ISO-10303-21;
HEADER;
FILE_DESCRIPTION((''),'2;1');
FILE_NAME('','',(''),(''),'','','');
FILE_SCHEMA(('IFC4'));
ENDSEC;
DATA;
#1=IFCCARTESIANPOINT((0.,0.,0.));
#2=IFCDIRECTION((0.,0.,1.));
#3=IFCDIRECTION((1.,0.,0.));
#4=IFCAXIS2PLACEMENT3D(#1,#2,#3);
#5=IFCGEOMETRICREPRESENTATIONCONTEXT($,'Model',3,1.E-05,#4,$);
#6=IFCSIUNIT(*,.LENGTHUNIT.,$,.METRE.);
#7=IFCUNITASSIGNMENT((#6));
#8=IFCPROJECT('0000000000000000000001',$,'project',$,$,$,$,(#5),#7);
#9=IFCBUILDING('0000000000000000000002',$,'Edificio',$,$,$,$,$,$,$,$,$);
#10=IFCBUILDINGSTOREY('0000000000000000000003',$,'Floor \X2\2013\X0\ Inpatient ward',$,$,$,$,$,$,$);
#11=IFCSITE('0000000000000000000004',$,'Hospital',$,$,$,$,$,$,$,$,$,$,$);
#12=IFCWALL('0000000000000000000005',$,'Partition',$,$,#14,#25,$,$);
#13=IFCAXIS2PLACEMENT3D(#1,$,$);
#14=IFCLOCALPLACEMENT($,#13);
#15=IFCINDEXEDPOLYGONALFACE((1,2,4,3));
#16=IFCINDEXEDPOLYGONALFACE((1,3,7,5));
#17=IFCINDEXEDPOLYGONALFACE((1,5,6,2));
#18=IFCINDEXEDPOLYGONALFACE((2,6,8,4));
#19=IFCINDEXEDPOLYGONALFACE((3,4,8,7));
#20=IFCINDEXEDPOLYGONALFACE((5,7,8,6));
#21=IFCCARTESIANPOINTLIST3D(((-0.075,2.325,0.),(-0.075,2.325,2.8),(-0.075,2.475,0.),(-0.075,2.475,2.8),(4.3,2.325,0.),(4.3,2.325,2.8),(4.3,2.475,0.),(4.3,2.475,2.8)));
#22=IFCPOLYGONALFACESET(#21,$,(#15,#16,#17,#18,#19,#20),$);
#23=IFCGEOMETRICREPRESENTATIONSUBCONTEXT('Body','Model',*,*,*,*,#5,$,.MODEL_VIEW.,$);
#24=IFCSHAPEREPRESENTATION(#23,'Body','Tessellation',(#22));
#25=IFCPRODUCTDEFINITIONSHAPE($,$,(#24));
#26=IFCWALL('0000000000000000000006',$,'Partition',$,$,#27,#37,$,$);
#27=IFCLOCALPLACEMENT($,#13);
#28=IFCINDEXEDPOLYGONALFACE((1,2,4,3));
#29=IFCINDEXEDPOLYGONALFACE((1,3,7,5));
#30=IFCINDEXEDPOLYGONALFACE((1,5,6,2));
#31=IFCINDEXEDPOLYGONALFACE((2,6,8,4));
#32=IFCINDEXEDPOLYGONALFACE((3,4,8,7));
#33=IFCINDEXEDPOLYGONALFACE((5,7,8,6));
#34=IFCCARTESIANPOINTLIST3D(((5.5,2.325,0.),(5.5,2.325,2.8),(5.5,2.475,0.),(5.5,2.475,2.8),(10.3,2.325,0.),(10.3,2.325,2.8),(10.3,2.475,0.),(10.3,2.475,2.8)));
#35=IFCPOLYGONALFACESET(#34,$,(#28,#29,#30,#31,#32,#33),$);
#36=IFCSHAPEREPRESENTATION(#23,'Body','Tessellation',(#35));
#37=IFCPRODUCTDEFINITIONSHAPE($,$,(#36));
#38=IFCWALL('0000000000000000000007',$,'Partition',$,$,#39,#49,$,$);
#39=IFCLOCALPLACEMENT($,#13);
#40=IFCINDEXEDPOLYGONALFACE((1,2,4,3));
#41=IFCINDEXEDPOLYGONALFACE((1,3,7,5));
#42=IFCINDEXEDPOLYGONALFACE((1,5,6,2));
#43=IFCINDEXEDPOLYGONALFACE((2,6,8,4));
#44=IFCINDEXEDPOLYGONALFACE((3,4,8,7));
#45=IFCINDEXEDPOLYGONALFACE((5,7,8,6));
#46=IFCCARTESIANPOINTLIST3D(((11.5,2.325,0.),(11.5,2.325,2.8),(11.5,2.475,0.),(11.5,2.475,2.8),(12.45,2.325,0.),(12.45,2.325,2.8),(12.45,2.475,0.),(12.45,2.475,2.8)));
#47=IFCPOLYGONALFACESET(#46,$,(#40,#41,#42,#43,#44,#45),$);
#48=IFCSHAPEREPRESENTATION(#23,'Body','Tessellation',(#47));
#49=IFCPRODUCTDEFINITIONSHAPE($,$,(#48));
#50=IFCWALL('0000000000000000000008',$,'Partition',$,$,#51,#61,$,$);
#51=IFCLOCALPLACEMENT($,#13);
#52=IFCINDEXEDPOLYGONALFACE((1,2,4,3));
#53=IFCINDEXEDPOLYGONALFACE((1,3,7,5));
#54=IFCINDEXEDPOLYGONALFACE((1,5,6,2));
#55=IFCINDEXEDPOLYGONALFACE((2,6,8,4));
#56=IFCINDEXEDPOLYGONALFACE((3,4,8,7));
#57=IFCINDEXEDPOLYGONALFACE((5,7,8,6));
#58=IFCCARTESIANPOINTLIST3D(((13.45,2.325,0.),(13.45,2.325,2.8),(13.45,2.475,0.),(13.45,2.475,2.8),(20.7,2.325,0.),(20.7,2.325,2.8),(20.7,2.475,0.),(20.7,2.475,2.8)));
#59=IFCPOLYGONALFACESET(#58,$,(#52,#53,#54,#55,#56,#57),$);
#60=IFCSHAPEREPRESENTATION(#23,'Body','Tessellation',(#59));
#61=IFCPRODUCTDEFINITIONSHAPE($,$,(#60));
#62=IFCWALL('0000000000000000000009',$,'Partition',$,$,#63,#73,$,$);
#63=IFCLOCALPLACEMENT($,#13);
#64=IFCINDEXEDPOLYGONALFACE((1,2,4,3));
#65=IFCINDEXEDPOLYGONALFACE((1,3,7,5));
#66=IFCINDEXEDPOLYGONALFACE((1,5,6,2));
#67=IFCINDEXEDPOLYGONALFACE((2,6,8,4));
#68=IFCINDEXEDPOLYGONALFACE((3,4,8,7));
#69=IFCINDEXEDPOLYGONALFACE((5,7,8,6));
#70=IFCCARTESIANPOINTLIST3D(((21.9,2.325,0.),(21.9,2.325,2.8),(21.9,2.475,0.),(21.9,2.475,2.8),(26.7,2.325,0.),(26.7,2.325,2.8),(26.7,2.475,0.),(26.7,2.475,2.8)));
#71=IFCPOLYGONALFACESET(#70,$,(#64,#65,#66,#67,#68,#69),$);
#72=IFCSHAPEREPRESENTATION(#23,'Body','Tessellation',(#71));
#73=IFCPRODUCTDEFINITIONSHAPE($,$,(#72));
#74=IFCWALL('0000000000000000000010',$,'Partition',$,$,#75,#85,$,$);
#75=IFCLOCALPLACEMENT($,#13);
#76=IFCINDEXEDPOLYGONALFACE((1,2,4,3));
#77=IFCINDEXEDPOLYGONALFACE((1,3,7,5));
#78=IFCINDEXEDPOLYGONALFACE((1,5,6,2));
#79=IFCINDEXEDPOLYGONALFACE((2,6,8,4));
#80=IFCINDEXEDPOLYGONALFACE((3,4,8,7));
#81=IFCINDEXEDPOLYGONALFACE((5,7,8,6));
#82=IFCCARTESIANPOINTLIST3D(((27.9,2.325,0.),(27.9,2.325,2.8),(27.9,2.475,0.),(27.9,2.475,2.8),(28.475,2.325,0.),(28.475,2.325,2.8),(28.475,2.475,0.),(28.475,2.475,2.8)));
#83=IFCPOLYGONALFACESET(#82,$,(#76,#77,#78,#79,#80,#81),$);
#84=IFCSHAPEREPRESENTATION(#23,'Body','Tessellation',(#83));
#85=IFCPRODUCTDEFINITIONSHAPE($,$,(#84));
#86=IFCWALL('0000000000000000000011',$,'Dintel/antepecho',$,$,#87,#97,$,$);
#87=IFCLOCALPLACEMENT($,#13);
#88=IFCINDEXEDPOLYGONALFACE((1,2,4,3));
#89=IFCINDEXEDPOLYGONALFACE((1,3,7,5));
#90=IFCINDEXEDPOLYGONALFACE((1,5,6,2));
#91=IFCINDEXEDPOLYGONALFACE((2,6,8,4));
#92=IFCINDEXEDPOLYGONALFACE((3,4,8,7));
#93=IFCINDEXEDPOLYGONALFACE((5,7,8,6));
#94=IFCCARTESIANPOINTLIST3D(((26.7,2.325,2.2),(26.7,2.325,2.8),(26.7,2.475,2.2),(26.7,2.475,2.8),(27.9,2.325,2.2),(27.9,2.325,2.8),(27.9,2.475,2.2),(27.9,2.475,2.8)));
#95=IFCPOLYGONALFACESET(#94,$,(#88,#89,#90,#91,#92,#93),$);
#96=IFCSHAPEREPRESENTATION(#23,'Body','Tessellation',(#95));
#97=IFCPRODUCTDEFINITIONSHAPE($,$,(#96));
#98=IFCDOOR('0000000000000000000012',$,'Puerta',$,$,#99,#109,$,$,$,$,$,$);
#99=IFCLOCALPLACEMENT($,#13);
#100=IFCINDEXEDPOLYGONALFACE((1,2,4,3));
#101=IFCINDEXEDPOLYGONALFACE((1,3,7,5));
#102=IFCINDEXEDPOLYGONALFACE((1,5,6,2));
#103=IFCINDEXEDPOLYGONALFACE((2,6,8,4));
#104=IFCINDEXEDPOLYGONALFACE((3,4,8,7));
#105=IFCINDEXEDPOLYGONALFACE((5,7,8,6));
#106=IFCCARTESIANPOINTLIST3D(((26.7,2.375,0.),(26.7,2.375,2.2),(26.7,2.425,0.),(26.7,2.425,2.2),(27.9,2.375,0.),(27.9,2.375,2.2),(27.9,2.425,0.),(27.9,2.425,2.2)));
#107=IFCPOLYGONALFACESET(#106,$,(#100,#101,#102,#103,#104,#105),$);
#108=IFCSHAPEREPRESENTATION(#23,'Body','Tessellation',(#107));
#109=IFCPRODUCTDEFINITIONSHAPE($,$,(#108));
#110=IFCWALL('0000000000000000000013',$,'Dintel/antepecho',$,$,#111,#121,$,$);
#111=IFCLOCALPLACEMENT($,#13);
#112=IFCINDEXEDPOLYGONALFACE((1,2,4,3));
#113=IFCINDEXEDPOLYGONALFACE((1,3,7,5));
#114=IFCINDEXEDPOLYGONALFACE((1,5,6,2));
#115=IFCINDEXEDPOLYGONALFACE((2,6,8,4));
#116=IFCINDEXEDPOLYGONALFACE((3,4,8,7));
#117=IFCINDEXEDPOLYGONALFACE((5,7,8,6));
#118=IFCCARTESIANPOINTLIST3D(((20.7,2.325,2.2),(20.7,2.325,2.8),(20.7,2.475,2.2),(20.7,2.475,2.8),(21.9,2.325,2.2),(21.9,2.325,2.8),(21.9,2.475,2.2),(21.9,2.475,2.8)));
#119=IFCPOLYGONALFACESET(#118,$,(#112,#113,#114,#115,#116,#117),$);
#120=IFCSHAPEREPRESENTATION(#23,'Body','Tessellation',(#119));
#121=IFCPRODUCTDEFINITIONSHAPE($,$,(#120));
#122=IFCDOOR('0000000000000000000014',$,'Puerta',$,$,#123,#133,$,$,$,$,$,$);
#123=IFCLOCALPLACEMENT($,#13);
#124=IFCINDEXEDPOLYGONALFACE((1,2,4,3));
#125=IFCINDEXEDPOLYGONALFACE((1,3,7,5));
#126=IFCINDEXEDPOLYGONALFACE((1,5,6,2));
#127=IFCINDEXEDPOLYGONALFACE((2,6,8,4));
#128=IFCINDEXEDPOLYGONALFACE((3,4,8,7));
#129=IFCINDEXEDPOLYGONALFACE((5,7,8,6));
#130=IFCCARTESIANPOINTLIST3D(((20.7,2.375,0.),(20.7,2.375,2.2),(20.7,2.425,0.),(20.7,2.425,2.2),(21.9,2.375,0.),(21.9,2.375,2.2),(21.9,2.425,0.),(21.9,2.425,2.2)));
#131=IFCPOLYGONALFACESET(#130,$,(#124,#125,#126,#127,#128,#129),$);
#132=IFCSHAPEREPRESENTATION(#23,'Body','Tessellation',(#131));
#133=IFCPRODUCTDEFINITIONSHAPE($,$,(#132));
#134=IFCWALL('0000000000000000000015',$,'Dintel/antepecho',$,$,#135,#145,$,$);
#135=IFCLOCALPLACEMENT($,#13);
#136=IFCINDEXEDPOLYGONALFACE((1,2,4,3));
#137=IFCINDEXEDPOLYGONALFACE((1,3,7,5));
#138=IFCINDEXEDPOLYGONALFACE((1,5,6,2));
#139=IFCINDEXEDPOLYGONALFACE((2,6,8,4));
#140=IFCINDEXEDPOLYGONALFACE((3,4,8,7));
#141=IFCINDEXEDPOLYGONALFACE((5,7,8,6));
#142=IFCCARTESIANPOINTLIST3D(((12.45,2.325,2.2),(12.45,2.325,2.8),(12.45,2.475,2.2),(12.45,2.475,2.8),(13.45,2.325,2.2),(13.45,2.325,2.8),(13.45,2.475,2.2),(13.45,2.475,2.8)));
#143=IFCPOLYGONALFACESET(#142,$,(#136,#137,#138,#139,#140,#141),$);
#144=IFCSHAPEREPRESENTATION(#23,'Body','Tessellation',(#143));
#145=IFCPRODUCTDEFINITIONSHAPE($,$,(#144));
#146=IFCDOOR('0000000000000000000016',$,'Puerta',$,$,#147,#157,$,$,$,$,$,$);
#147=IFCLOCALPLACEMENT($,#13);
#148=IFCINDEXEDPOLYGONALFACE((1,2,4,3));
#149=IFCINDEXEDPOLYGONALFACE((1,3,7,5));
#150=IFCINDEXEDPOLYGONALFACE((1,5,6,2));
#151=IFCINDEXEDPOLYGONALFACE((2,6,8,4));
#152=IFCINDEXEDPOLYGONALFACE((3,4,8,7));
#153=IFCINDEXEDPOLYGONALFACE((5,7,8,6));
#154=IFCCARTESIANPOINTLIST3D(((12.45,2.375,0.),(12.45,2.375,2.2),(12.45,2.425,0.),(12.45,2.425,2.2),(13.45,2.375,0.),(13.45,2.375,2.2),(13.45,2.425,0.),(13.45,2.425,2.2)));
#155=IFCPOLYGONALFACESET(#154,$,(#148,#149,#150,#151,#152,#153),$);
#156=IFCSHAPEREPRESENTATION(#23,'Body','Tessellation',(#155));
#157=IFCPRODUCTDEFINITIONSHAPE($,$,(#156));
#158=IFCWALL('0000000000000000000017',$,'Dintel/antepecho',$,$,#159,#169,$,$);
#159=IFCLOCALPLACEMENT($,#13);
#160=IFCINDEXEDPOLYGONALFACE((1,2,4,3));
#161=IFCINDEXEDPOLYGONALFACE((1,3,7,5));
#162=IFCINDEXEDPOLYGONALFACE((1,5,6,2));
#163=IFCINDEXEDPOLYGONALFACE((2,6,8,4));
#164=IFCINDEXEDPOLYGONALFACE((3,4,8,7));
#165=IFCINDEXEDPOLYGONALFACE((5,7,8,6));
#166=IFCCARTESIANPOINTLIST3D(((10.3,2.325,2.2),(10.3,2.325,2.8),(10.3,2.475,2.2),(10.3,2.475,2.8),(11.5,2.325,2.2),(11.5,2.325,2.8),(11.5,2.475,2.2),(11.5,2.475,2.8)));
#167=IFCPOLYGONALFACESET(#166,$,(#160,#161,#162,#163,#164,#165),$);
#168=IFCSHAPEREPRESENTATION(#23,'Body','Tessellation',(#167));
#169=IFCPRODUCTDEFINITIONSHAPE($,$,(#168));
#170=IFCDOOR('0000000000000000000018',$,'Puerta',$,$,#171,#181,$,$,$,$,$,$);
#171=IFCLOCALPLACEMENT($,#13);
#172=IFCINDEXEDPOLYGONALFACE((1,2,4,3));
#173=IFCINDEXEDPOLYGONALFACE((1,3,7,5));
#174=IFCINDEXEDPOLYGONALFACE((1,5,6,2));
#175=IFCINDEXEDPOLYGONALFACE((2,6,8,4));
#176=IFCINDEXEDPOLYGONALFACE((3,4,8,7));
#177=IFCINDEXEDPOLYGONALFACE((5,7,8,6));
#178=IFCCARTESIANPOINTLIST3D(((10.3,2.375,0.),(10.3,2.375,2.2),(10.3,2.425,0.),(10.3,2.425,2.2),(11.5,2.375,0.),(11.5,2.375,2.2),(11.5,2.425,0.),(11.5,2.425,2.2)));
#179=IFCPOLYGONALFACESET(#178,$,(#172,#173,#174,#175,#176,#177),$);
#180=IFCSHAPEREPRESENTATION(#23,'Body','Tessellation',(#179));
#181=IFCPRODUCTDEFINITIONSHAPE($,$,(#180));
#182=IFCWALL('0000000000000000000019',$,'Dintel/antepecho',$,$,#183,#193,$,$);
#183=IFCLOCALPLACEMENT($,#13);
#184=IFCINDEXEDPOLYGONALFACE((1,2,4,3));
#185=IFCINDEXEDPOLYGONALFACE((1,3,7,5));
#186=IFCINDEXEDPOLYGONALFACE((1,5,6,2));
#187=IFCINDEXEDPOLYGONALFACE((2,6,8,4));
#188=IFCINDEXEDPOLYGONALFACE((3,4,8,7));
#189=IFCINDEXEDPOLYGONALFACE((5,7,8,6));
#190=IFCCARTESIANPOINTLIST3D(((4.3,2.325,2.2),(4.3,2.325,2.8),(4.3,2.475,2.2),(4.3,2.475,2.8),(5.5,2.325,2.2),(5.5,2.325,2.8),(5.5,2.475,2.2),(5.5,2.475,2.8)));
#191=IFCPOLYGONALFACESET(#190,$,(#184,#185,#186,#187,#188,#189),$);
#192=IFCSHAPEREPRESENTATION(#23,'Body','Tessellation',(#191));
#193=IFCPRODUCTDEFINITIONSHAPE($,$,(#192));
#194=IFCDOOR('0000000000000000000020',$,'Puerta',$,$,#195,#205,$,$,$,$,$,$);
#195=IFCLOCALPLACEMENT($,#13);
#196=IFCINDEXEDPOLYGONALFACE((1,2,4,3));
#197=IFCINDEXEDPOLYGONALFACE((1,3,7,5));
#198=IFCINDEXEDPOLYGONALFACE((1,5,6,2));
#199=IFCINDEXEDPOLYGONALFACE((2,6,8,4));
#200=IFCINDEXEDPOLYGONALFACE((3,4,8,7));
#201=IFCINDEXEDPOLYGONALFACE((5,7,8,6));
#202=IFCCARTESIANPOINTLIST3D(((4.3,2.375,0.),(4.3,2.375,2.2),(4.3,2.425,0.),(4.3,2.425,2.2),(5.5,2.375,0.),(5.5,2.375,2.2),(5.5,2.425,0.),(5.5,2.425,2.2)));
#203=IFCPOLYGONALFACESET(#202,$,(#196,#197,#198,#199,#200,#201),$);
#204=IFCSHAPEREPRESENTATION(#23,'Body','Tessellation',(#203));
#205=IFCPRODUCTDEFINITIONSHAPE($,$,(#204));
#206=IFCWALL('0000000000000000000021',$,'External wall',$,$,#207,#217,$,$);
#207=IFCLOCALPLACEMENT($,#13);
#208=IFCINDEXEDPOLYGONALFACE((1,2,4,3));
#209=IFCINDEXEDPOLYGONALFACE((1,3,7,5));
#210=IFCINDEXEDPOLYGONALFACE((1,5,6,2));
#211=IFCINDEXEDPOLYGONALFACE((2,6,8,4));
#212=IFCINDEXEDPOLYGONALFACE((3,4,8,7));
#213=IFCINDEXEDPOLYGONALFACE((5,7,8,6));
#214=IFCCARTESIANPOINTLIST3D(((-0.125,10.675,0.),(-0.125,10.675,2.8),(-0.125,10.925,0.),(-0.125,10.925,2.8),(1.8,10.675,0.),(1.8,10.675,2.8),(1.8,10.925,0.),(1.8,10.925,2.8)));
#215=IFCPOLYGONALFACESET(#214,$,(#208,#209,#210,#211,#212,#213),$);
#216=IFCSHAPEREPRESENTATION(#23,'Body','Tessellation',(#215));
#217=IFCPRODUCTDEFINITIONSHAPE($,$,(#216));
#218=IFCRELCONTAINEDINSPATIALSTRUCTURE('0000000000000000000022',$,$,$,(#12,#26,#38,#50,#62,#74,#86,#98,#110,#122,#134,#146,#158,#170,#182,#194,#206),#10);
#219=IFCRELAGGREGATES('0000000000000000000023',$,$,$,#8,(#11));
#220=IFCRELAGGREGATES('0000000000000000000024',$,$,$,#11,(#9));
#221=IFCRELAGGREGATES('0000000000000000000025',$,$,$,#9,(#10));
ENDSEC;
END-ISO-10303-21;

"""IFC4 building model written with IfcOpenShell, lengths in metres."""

from ifc_helpers import new_model, si_unit, frame, origin_with_axes, context, subcontext, project, spatial, line, indexed_curve, outline, extrude, element, save


model = new_model("IFC4")

# Units and contexts
model_context = context("Model", 3, precision=1e-05, world=origin_with_axes())
body_context = subcontext(model_context, "Body", "Model", "MODEL_VIEW")
ifc_project = project(units=[si_unit("LENGTHUNIT", "METRE")], contexts=[model_context])

# Site, building, storey
site = spatial("IfcSite", under=ifc_project, Name="Hospital")
building = spatial("IfcBuilding", under=site, Name="Edificio")
storey = spatial("IfcBuildingStorey", under=building, Name="Floor – Inpatient ward")

# Walls
element("IfcWall", 1, inside=storey, Name="Partition", context=body_context, shape_type="SweptSolid", body=[
    extrude(outline(indexed_curve([(0.0, 0.0), (4.375, 0.0), (4.375, 0.15), (0.0, 0.15)], segments=[line(1, 2, 3, 4, 1)])), frame((-0.075, 2.325, 0.0), z_axis=(0.0, 0.0, 1.0), x_axis=(1.0, 0.0, 0.0)), (0.0, 0.0, 1.0), 2.8),
])
element("IfcWall", 2, inside=storey, Name="Partition", context=body_context, shape_type="SweptSolid", body=[
    extrude(outline(indexed_curve([(0.0, 0.0), (4.8, 0.0), (4.8, 0.15), (0.0, 0.15)], segments=[line(1, 2, 3, 4, 1)])), frame((5.5, 2.325, 0.0), z_axis=(0.0, 0.0, 1.0), x_axis=(1.0, 0.0, 0.0)), (0.0, 0.0, 1.0), 2.8),
])
element("IfcWall", 3, inside=storey, Name="Partition", context=body_context, shape_type="SweptSolid", body=[
    extrude(outline(indexed_curve([(0.0, 0.0), (0.95, 0.0), (0.95, 0.15), (0.0, 0.15)], segments=[line(1, 2, 3, 4, 1)])), frame((11.5, 2.325, 0.0), z_axis=(0.0, 0.0, 1.0), x_axis=(1.0, 0.0, 0.0)), (0.0, 0.0, 1.0), 2.8),
])
element("IfcWall", 4, inside=storey, Name="Partition", context=body_context, shape_type="SweptSolid", body=[
    extrude(outline(indexed_curve([(0.0, 0.0), (7.25, 0.0), (7.25, 0.15), (0.0, 0.15)], segments=[line(1, 2, 3, 4, 1)])), frame((13.45, 2.325, 0.0), z_axis=(0.0, 0.0, 1.0), x_axis=(1.0, 0.0, 0.0)), (0.0, 0.0, 1.0), 2.8),
])
element("IfcWall", 5, inside=storey, Name="Partition", context=body_context, shape_type="SweptSolid", body=[
    extrude(outline(indexed_curve([(0.0, 0.0), (4.8, 0.0), (4.8, 0.15), (0.0, 0.15)], segments=[line(1, 2, 3, 4, 1)])), frame((21.9, 2.325, 0.0), z_axis=(0.0, 0.0, 1.0), x_axis=(1.0, 0.0, 0.0)), (0.0, 0.0, 1.0), 2.8),
])
element("IfcWall", 6, inside=storey, Name="Partition", context=body_context, shape_type="SweptSolid", body=[
    extrude(outline(indexed_curve([(0.0, 0.0), (0.575, 0.0), (0.575, 0.15), (0.0, 0.15)], segments=[line(1, 2, 3, 4, 1)])), frame((27.9, 2.325, 0.0), z_axis=(0.0, 0.0, 1.0), x_axis=(1.0, 0.0, 0.0)), (0.0, 0.0, 1.0), 2.8),
])
element("IfcWall", 7, inside=storey, Name="Dintel/antepecho", context=body_context, shape_type="SweptSolid", body=[
    extrude(outline(indexed_curve([(0.0, 0.0), (1.2, 0.0), (1.2, 0.15), (0.0, 0.15)], segments=[line(1, 2, 3, 4, 1)])), frame((26.7, 2.325, 2.2), z_axis=(0.0, 0.0, 1.0), x_axis=(1.0, 0.0, 0.0)), (0.0, 0.0, 1.0), 0.6),
])

# Door
element("IfcDoor", 8, inside=storey, Name="Puerta", context=body_context, shape_type="SweptSolid", body=[
    extrude(outline(indexed_curve([(0.0, 0.0), (1.2, 0.0), (1.2, 0.05), (0.0, 0.05)], segments=[line(1, 2, 3, 4, 1)])), frame((26.7, 2.375, 0.0), z_axis=(0.0, 0.0, 1.0), x_axis=(1.0, 0.0, 0.0)), (0.0, 0.0, 1.0), 2.2),
])

# Wall
element("IfcWall", 9, inside=storey, Name="Dintel/antepecho", context=body_context, shape_type="SweptSolid", body=[
    extrude(outline(indexed_curve([(0.0, 0.0), (1.2, 0.0), (1.2, 0.15), (0.0, 0.15)], segments=[line(1, 2, 3, 4, 1)])), frame((20.7, 2.325, 2.2), z_axis=(0.0, 0.0, 1.0), x_axis=(1.0, 0.0, 0.0)), (0.0, 0.0, 1.0), 0.6),
])

# Door
element("IfcDoor", 10, inside=storey, Name="Puerta", context=body_context, shape_type="SweptSolid", body=[
    extrude(outline(indexed_curve([(0.0, 0.0), (1.2, 0.0), (1.2, 0.05), (0.0, 0.05)], segments=[line(1, 2, 3, 4, 1)])), frame((20.7, 2.375, 0.0), z_axis=(0.0, 0.0, 1.0), x_axis=(1.0, 0.0, 0.0)), (0.0, 0.0, 1.0), 2.2),
])

# Wall
element("IfcWall", 11, inside=storey, Name="Dintel/antepecho", context=body_context, shape_type="SweptSolid", body=[
    extrude(outline(indexed_curve([(0.0, 0.0), (1.0, 0.0), (1.0, 0.15), (0.0, 0.15)], segments=[line(1, 2, 3, 4, 1)])), frame((12.45, 2.325, 2.2), z_axis=(0.0, 0.0, 1.0), x_axis=(1.0, 0.0, 0.0)), (0.0, 0.0, 1.0), 0.6),
])

# Door
element("IfcDoor", 12, inside=storey, Name="Puerta", context=body_context, shape_type="SweptSolid", body=[
    extrude(outline(indexed_curve([(0.0, 0.0), (1.0, 0.0), (1.0, 0.05), (0.0, 0.05)], segments=[line(1, 2, 3, 4, 1)])), frame((12.45, 2.375, 0.0), z_axis=(0.0, 0.0, 1.0), x_axis=(1.0, 0.0, 0.0)), (0.0, 0.0, 1.0), 2.2),
])

# Wall
element("IfcWall", 13, inside=storey, Name="Dintel/antepecho", context=body_context, shape_type="SweptSolid", body=[
    extrude(outline(indexed_curve([(0.0, 0.0), (1.2, 0.0), (1.2, 0.15), (0.0, 0.15)], segments=[line(1, 2, 3, 4, 1)])), frame((10.3, 2.325, 2.2), z_axis=(0.0, 0.0, 1.0), x_axis=(1.0, 0.0, 0.0)), (0.0, 0.0, 1.0), 0.6),
])

# Door
element("IfcDoor", 14, inside=storey, Name="Puerta", context=body_context, shape_type="SweptSolid", body=[
    extrude(outline(indexed_curve([(0.0, 0.0), (1.2, 0.0), (1.2, 0.05), (0.0, 0.05)], segments=[line(1, 2, 3, 4, 1)])), frame((10.3, 2.375, 0.0), z_axis=(0.0, 0.0, 1.0), x_axis=(1.0, 0.0, 0.0)), (0.0, 0.0, 1.0), 2.2),
])

# Wall
element("IfcWall", 15, inside=storey, Name="Dintel/antepecho", context=body_context, shape_type="SweptSolid", body=[
    extrude(outline(indexed_curve([(0.0, 0.0), (1.2, 0.0), (1.2, 0.15), (0.0, 0.15)], segments=[line(1, 2, 3, 4, 1)])), frame((4.3, 2.325, 2.2), z_axis=(0.0, 0.0, 1.0), x_axis=(1.0, 0.0, 0.0)), (0.0, 0.0, 1.0), 0.6),
])

# Door
element("IfcDoor", 16, inside=storey, Name="Puerta", context=body_context, shape_type="SweptSolid", body=[
    extrude(outline(indexed_curve([(0.0, 0.0), (1.2, 0.0), (1.2, 0.05), (0.0, 0.05)], segments=[line(1, 2, 3, 4, 1)])), frame((4.3, 2.375, 0.0), z_axis=(0.0, 0.0, 1.0), x_axis=(1.0, 0.0, 0.0)), (0.0, 0.0, 1.0), 2.2),
])

# Wall
element("IfcWall", 17, inside=storey, Name="External wall", context=body_context, shape_type="SweptSolid", body=[
    extrude(outline(indexed_curve([(0.0, 0.0), (1.925, 0.0), (1.925, 0.25), (0.0, 0.25)], segments=[line(1, 2, 3, 4, 1)])), frame((-0.125, 10.675, 0.0), z_axis=(0.0, 0.0, 1.0), x_axis=(1.0, 0.0, 0.0)), (0.0, 0.0, 1.0), 2.8),
])

save(model, "model.ifc")
